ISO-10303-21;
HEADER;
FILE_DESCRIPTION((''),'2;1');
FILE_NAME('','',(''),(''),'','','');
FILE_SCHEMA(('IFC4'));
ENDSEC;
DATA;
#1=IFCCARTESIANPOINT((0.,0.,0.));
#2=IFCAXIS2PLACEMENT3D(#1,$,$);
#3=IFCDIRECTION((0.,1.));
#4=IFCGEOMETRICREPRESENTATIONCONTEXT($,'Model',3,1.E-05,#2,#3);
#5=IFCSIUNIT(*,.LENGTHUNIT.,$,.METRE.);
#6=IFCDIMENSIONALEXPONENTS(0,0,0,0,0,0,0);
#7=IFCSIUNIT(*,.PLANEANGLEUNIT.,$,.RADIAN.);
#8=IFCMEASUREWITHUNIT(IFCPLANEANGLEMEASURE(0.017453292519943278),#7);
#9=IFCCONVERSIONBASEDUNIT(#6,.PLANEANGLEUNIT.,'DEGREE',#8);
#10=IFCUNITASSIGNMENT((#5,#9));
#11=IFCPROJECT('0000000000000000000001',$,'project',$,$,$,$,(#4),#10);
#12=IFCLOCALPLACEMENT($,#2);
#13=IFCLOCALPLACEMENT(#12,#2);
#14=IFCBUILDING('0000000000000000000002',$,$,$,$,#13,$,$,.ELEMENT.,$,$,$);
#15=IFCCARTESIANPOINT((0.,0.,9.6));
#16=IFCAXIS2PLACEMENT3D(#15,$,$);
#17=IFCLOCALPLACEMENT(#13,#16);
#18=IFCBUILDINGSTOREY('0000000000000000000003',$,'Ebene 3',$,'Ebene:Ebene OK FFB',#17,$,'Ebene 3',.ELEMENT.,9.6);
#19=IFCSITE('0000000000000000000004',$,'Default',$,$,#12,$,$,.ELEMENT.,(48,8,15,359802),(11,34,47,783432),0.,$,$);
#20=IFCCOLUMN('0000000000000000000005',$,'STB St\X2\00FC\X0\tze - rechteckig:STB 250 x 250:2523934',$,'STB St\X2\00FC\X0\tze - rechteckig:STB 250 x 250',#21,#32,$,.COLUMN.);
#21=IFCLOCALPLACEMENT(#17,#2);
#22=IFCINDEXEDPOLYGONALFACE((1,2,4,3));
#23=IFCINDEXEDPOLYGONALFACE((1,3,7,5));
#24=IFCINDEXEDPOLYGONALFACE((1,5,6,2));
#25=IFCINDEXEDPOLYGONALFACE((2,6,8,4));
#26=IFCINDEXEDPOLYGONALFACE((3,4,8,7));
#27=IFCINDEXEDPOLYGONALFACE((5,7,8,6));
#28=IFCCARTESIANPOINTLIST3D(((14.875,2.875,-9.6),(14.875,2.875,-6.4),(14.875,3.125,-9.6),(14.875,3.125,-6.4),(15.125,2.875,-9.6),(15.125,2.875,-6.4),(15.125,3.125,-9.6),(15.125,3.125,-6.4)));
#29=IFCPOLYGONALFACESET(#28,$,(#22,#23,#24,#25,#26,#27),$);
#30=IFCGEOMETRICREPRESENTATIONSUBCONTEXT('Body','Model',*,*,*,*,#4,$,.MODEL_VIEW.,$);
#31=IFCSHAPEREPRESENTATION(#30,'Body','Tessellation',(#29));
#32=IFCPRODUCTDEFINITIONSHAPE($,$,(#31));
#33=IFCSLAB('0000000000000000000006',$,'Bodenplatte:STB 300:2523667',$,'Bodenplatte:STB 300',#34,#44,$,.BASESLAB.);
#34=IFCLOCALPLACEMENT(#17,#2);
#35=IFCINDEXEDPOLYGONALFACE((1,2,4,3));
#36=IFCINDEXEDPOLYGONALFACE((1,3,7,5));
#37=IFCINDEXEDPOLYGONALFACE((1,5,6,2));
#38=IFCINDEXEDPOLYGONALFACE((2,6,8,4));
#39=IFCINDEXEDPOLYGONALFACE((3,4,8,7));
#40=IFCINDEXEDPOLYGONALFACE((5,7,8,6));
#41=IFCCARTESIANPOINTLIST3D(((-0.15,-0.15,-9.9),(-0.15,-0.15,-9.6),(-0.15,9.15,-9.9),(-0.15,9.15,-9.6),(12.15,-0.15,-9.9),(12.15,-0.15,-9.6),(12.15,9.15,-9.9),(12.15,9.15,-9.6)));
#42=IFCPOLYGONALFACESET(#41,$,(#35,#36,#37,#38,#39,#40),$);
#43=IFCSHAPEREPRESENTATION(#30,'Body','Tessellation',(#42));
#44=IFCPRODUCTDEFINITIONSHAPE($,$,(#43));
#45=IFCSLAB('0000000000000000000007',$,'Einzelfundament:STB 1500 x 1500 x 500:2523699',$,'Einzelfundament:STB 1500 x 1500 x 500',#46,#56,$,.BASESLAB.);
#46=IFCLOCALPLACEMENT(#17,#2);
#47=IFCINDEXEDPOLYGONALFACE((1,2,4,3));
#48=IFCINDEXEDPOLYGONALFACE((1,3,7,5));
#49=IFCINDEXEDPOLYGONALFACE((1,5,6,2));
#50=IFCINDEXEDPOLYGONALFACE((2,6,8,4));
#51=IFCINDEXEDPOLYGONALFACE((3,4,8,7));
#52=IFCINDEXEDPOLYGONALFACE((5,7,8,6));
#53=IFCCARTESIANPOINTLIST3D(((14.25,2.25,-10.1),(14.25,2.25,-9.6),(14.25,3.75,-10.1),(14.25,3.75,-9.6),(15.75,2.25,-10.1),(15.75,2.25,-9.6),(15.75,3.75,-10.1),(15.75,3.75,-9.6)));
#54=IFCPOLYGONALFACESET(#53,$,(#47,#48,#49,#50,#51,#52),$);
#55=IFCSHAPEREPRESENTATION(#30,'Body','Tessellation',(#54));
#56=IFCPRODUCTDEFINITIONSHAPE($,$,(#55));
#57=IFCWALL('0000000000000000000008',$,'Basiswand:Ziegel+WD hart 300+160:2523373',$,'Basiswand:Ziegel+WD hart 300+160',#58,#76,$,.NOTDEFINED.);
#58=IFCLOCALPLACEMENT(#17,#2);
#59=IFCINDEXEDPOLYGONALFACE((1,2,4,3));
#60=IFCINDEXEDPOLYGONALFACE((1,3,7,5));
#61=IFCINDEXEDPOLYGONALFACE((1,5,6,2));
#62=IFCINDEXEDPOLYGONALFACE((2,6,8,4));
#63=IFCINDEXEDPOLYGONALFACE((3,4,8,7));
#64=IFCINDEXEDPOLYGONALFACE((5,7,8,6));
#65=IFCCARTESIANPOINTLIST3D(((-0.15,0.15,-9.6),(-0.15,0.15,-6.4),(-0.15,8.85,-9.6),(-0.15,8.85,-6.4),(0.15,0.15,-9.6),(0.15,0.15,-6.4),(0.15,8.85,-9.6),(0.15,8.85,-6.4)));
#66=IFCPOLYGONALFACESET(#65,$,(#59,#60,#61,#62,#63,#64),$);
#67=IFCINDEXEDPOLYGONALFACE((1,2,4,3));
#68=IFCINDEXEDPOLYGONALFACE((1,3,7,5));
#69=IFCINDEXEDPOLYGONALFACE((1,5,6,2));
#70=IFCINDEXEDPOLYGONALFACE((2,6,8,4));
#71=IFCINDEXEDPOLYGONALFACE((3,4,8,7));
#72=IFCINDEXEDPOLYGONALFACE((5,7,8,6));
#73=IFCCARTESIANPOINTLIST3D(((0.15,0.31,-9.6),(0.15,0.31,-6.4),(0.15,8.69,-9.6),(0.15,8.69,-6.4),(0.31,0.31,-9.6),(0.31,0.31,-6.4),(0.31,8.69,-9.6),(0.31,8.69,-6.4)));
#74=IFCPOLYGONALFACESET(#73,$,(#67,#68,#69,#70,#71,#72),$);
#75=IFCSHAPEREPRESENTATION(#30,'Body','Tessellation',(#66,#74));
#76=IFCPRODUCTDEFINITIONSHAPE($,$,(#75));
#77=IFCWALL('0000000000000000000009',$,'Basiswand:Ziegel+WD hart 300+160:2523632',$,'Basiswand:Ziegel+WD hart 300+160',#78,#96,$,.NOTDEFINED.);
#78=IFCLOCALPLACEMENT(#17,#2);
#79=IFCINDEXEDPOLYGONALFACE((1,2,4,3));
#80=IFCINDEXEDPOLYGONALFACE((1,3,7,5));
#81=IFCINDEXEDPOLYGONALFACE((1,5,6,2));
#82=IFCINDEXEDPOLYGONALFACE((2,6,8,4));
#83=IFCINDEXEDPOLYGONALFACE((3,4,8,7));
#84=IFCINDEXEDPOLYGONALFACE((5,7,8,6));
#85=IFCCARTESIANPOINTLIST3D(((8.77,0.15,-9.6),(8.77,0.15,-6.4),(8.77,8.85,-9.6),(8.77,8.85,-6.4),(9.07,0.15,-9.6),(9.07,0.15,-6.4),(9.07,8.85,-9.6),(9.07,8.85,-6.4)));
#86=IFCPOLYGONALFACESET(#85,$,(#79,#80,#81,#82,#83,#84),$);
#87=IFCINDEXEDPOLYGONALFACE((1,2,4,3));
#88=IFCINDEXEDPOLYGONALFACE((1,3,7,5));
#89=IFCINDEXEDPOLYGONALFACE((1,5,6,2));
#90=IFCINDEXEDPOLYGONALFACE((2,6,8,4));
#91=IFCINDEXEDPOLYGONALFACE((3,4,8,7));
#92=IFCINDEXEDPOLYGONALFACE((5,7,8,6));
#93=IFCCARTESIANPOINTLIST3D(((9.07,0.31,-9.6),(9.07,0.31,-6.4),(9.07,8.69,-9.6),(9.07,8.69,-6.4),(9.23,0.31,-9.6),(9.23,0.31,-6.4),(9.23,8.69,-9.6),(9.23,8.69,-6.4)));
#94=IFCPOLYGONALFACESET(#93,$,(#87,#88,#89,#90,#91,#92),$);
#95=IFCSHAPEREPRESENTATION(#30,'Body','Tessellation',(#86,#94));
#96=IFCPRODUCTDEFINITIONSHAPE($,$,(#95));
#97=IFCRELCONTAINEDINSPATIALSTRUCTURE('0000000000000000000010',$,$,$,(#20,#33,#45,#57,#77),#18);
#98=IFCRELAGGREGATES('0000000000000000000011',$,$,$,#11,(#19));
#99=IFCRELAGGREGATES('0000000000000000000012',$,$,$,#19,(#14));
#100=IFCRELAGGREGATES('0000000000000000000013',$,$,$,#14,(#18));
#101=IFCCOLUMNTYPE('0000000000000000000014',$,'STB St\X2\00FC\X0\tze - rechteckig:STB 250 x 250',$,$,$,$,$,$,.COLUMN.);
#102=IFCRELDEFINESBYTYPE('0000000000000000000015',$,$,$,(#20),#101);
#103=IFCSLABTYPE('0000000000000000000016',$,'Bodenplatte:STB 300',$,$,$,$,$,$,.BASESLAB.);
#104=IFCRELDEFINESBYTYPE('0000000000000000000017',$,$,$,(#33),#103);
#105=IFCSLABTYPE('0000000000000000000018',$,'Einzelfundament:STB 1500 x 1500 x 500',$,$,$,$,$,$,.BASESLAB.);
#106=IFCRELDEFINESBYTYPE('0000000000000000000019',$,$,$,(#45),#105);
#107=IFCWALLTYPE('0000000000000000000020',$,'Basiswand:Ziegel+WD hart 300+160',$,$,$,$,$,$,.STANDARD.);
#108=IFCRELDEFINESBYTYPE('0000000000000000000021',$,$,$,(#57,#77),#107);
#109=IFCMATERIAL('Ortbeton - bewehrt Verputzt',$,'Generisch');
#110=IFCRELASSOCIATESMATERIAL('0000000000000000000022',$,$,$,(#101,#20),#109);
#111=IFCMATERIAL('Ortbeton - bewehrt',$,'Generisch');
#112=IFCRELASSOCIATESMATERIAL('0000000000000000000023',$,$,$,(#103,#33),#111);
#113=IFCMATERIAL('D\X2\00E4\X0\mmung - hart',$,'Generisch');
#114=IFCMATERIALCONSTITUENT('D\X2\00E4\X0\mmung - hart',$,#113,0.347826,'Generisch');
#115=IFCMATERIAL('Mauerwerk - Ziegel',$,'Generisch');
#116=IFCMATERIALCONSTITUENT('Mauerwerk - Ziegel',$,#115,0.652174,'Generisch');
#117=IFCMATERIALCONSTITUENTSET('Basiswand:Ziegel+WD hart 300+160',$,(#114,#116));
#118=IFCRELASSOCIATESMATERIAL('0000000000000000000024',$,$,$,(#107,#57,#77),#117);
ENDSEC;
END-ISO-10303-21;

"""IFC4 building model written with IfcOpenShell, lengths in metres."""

from ifc_helpers import new_model, entity, si_unit, converted_unit, direction, frame, origin, place, context, subcontext, project, spatial, indexed_curve, outline, extrude, source, transform, mapped, material, constituent, constituent_set, type_object, type_shapes, element, save


model = new_model("IFC4")

# Units and contexts
model_context = context("Model", 3, precision=1e-05, world=origin(), true_north=direction((0.0, 1.0)))
body_context = subcontext(model_context, "Body", "Model", "MODEL_VIEW")
ifc_project = project(units=[si_unit("LENGTHUNIT", "METRE"), converted_unit("PLANEANGLEUNIT", "DEGREE", entity("IfcPlaneAngleMeasure", 0.017453292519943278), si_unit("PLANEANGLEUNIT", "RADIAN"), dimensions=[0, 0, 0, 0, 0, 0, 0])], contexts=[model_context])

# Site, building, storey
site_placement = place(None, origin())
site = spatial("IfcSite", under=ifc_project, at=site_placement, Name="Default", CompositionType="ELEMENT", RefLatitude=(48, 8, 15, 359802), RefLongitude=(11, 34, 47, 783432), RefElevation=0.0)
building_placement = place(site_placement, origin())
building = spatial("IfcBuilding", under=site, at=building_placement, CompositionType="ELEMENT")
storey_placement = place(building_placement, frame((0.0, 0.0, 9.6)))
storey = spatial("IfcBuildingStorey", under=building, at=storey_placement, Name="Ebene 3", ObjectType="Ebene:Ebene OK FFB", LongName="Ebene 3", CompositionType="ELEMENT", Elevation=9.6)

# Column
ifc_material_1 = material(Name="Ortbeton - bewehrt Verputzt", Category="Generisch")
column_type = type_object("IfcColumnType", Name="STB Stütze - rechteckig:STB 250 x 250", PredefinedType="COLUMN", material=ifc_material_1)
shared_shape = source(origin(), body_context, "Body", "SweptSolid", [
    extrude(outline(indexed_curve([(-0.125, -0.125), (0.125, -0.125), (0.125, 0.125), (-0.125, 0.125), (-0.125, -0.125)], self_intersect=False)), frame((0.0, 0.0, 0.0), z_axis=(0.0, 0.0, 1.0), x_axis=(-1.0, 0.0, 0.0)), (0.0, 0.0, 1.0), 3.2),
])
type_shapes(column_type, [shared_shape])
column_placement = place(storey_placement, frame((15.0, 3.0, -9.6)))
element("IfcColumn", 1, at=column_placement, inside=storey, type_object=column_type, material=ifc_material_1, Name="STB Stütze - rechteckig:STB 250 x 250:2523934", ObjectType="STB Stütze - rechteckig:STB 250 x 250", PredefinedType="COLUMN", context=body_context, shape_type="MappedRepresentation", body=[
    mapped(shared_shape, transform((0.0, 0.0, 0.0), scale=1.0)),
])

# Slabs
ifc_material_2 = material(Name="Ortbeton - bewehrt", Category="Generisch")
slab_type_1 = type_object("IfcSlabType", Name="Bodenplatte:STB 300", PredefinedType="BASESLAB", material=ifc_material_2)
slab_1_placement = place(storey_placement, origin())
element("IfcSlab", 2, at=slab_1_placement, inside=storey, type_object=slab_type_1, material=ifc_material_2, Name="Bodenplatte:STB 300:2523667", ObjectType="Bodenplatte:STB 300", PredefinedType="BASESLAB", context=body_context, shape_type="SweptSolid", body=[
    extrude(outline(indexed_curve([(-4.65, -6.15), (4.65, -6.15), (4.65, 6.15), (-4.65, 6.15), (-4.65, -6.15)], self_intersect=False)), frame((6.0, 4.5, -9.6), z_axis=(0.0, 0.0, -1.0), x_axis=(0.0, 1.0, 0.0)), (0.0, 0.0, 1.0), 0.3),
])
slab_type_2 = type_object("IfcSlabType", Name="Einzelfundament:STB 1500 x 1500 x 500", PredefinedType="BASESLAB")
slab_2_placement = place(storey_placement, origin())
element("IfcSlab", 3, at=slab_2_placement, inside=storey, type_object=slab_type_2, Name="Einzelfundament:STB 1500 x 1500 x 500:2523699", ObjectType="Einzelfundament:STB 1500 x 1500 x 500", PredefinedType="BASESLAB", context=body_context, shape_type="SweptSolid", body=[
    extrude(outline(indexed_curve([(-0.75, -0.75), (0.75, -0.75), (0.75, 0.75), (-0.75, 0.75), (-0.75, -0.75)], self_intersect=False)), frame((15.0, 3.0, -10.1), z_axis=(0.0, 0.0, 1.0), x_axis=(-1.0, 0.0, 0.0)), (0.0, 0.0, 1.0), 0.5),
])

# Shared definitions
ifc_material_3 = material(Name="Dämmung - hart", Category="Generisch")
ifc_constituent_1 = constituent(ifc_material_3, Name="Dämmung - hart", Category="Generisch", fraction=0.347826)
ifc_material_4 = material(Name="Mauerwerk - Ziegel", Category="Generisch")
ifc_constituent_2 = constituent(ifc_material_4, Name="Mauerwerk - Ziegel", Category="Generisch", fraction=0.652174)
ifc_constituent_set = constituent_set(constituents=[ifc_constituent_1, ifc_constituent_2], Name="Basiswand:Ziegel+WD hart 300+160")
wall_type = type_object("IfcWallType", Name="Basiswand:Ziegel+WD hart 300+160", PredefinedType="STANDARD", material=ifc_constituent_set)

# Walls
wall_1_placement = place(storey_placement, frame((0.08, 8.69, -9.6), z_axis=(0.0, 0.0, 1.0), x_axis=(0.0, -1.0, 0.0)))
element("IfcWall", 4, at=wall_1_placement, inside=storey, type_object=wall_type, material=ifc_constituent_set, Name="Basiswand:Ziegel+WD hart 300+160:2523373", ObjectType="Basiswand:Ziegel+WD hart 300+160", PredefinedType="NOTDEFINED", context=body_context, shape_type="SweptSolid", body=[
    extrude(outline(indexed_curve([(-0.15, -4.35), (0.15, -4.35), (0.15, 4.35), (-0.15, 4.35), (-0.15, -4.35)], self_intersect=False)), frame((4.19, -0.08, 0.0), z_axis=(0.0, 0.0, 1.0), x_axis=(0.0, 1.0, 0.0)), (0.0, 0.0, 1.0), 3.2),
    extrude(outline(indexed_curve([(-0.08, -4.19), (0.08, -4.19), (0.08, 4.19), (-0.08, 4.19), (-0.08, -4.19)], self_intersect=False)), frame((4.19, 0.15, 0.0), z_axis=(0.0, 0.0, 1.0), x_axis=(0.0, -1.0, 0.0)), (0.0, 0.0, 1.0), 3.2),
])
wall_2_placement = place(storey_placement, frame((9.0, 8.69, -9.6), z_axis=(0.0, 0.0, 1.0), x_axis=(0.0, -1.0, 0.0)))
element("IfcWall", 5, at=wall_2_placement, inside=storey, type_object=wall_type, material=ifc_constituent_set, Name="Basiswand:Ziegel+WD hart 300+160:2523632", ObjectType="Basiswand:Ziegel+WD hart 300+160", PredefinedType="NOTDEFINED", context=body_context, shape_type="SweptSolid", body=[
    extrude(outline(indexed_curve([(-0.15, -4.35), (0.15, -4.35), (0.15, 4.35), (-0.15, 4.35), (-0.15, -4.35)], self_intersect=False)), frame((4.19, -0.08, 0.0), z_axis=(0.0, 0.0, 1.0), x_axis=(0.0, 1.0, 0.0)), (0.0, 0.0, 1.0), 3.2),
    extrude(outline(indexed_curve([(-0.08, -4.19), (0.08, -4.19), (0.08, 4.19), (-0.08, 4.19), (-0.08, -4.19)], self_intersect=False)), frame((4.19, 0.15, 0.0), z_axis=(0.0, 0.0, 1.0), x_axis=(0.0, -1.0, 0.0)), (0.0, 0.0, 1.0), 3.2),
])

save(model, "model.ifc")
